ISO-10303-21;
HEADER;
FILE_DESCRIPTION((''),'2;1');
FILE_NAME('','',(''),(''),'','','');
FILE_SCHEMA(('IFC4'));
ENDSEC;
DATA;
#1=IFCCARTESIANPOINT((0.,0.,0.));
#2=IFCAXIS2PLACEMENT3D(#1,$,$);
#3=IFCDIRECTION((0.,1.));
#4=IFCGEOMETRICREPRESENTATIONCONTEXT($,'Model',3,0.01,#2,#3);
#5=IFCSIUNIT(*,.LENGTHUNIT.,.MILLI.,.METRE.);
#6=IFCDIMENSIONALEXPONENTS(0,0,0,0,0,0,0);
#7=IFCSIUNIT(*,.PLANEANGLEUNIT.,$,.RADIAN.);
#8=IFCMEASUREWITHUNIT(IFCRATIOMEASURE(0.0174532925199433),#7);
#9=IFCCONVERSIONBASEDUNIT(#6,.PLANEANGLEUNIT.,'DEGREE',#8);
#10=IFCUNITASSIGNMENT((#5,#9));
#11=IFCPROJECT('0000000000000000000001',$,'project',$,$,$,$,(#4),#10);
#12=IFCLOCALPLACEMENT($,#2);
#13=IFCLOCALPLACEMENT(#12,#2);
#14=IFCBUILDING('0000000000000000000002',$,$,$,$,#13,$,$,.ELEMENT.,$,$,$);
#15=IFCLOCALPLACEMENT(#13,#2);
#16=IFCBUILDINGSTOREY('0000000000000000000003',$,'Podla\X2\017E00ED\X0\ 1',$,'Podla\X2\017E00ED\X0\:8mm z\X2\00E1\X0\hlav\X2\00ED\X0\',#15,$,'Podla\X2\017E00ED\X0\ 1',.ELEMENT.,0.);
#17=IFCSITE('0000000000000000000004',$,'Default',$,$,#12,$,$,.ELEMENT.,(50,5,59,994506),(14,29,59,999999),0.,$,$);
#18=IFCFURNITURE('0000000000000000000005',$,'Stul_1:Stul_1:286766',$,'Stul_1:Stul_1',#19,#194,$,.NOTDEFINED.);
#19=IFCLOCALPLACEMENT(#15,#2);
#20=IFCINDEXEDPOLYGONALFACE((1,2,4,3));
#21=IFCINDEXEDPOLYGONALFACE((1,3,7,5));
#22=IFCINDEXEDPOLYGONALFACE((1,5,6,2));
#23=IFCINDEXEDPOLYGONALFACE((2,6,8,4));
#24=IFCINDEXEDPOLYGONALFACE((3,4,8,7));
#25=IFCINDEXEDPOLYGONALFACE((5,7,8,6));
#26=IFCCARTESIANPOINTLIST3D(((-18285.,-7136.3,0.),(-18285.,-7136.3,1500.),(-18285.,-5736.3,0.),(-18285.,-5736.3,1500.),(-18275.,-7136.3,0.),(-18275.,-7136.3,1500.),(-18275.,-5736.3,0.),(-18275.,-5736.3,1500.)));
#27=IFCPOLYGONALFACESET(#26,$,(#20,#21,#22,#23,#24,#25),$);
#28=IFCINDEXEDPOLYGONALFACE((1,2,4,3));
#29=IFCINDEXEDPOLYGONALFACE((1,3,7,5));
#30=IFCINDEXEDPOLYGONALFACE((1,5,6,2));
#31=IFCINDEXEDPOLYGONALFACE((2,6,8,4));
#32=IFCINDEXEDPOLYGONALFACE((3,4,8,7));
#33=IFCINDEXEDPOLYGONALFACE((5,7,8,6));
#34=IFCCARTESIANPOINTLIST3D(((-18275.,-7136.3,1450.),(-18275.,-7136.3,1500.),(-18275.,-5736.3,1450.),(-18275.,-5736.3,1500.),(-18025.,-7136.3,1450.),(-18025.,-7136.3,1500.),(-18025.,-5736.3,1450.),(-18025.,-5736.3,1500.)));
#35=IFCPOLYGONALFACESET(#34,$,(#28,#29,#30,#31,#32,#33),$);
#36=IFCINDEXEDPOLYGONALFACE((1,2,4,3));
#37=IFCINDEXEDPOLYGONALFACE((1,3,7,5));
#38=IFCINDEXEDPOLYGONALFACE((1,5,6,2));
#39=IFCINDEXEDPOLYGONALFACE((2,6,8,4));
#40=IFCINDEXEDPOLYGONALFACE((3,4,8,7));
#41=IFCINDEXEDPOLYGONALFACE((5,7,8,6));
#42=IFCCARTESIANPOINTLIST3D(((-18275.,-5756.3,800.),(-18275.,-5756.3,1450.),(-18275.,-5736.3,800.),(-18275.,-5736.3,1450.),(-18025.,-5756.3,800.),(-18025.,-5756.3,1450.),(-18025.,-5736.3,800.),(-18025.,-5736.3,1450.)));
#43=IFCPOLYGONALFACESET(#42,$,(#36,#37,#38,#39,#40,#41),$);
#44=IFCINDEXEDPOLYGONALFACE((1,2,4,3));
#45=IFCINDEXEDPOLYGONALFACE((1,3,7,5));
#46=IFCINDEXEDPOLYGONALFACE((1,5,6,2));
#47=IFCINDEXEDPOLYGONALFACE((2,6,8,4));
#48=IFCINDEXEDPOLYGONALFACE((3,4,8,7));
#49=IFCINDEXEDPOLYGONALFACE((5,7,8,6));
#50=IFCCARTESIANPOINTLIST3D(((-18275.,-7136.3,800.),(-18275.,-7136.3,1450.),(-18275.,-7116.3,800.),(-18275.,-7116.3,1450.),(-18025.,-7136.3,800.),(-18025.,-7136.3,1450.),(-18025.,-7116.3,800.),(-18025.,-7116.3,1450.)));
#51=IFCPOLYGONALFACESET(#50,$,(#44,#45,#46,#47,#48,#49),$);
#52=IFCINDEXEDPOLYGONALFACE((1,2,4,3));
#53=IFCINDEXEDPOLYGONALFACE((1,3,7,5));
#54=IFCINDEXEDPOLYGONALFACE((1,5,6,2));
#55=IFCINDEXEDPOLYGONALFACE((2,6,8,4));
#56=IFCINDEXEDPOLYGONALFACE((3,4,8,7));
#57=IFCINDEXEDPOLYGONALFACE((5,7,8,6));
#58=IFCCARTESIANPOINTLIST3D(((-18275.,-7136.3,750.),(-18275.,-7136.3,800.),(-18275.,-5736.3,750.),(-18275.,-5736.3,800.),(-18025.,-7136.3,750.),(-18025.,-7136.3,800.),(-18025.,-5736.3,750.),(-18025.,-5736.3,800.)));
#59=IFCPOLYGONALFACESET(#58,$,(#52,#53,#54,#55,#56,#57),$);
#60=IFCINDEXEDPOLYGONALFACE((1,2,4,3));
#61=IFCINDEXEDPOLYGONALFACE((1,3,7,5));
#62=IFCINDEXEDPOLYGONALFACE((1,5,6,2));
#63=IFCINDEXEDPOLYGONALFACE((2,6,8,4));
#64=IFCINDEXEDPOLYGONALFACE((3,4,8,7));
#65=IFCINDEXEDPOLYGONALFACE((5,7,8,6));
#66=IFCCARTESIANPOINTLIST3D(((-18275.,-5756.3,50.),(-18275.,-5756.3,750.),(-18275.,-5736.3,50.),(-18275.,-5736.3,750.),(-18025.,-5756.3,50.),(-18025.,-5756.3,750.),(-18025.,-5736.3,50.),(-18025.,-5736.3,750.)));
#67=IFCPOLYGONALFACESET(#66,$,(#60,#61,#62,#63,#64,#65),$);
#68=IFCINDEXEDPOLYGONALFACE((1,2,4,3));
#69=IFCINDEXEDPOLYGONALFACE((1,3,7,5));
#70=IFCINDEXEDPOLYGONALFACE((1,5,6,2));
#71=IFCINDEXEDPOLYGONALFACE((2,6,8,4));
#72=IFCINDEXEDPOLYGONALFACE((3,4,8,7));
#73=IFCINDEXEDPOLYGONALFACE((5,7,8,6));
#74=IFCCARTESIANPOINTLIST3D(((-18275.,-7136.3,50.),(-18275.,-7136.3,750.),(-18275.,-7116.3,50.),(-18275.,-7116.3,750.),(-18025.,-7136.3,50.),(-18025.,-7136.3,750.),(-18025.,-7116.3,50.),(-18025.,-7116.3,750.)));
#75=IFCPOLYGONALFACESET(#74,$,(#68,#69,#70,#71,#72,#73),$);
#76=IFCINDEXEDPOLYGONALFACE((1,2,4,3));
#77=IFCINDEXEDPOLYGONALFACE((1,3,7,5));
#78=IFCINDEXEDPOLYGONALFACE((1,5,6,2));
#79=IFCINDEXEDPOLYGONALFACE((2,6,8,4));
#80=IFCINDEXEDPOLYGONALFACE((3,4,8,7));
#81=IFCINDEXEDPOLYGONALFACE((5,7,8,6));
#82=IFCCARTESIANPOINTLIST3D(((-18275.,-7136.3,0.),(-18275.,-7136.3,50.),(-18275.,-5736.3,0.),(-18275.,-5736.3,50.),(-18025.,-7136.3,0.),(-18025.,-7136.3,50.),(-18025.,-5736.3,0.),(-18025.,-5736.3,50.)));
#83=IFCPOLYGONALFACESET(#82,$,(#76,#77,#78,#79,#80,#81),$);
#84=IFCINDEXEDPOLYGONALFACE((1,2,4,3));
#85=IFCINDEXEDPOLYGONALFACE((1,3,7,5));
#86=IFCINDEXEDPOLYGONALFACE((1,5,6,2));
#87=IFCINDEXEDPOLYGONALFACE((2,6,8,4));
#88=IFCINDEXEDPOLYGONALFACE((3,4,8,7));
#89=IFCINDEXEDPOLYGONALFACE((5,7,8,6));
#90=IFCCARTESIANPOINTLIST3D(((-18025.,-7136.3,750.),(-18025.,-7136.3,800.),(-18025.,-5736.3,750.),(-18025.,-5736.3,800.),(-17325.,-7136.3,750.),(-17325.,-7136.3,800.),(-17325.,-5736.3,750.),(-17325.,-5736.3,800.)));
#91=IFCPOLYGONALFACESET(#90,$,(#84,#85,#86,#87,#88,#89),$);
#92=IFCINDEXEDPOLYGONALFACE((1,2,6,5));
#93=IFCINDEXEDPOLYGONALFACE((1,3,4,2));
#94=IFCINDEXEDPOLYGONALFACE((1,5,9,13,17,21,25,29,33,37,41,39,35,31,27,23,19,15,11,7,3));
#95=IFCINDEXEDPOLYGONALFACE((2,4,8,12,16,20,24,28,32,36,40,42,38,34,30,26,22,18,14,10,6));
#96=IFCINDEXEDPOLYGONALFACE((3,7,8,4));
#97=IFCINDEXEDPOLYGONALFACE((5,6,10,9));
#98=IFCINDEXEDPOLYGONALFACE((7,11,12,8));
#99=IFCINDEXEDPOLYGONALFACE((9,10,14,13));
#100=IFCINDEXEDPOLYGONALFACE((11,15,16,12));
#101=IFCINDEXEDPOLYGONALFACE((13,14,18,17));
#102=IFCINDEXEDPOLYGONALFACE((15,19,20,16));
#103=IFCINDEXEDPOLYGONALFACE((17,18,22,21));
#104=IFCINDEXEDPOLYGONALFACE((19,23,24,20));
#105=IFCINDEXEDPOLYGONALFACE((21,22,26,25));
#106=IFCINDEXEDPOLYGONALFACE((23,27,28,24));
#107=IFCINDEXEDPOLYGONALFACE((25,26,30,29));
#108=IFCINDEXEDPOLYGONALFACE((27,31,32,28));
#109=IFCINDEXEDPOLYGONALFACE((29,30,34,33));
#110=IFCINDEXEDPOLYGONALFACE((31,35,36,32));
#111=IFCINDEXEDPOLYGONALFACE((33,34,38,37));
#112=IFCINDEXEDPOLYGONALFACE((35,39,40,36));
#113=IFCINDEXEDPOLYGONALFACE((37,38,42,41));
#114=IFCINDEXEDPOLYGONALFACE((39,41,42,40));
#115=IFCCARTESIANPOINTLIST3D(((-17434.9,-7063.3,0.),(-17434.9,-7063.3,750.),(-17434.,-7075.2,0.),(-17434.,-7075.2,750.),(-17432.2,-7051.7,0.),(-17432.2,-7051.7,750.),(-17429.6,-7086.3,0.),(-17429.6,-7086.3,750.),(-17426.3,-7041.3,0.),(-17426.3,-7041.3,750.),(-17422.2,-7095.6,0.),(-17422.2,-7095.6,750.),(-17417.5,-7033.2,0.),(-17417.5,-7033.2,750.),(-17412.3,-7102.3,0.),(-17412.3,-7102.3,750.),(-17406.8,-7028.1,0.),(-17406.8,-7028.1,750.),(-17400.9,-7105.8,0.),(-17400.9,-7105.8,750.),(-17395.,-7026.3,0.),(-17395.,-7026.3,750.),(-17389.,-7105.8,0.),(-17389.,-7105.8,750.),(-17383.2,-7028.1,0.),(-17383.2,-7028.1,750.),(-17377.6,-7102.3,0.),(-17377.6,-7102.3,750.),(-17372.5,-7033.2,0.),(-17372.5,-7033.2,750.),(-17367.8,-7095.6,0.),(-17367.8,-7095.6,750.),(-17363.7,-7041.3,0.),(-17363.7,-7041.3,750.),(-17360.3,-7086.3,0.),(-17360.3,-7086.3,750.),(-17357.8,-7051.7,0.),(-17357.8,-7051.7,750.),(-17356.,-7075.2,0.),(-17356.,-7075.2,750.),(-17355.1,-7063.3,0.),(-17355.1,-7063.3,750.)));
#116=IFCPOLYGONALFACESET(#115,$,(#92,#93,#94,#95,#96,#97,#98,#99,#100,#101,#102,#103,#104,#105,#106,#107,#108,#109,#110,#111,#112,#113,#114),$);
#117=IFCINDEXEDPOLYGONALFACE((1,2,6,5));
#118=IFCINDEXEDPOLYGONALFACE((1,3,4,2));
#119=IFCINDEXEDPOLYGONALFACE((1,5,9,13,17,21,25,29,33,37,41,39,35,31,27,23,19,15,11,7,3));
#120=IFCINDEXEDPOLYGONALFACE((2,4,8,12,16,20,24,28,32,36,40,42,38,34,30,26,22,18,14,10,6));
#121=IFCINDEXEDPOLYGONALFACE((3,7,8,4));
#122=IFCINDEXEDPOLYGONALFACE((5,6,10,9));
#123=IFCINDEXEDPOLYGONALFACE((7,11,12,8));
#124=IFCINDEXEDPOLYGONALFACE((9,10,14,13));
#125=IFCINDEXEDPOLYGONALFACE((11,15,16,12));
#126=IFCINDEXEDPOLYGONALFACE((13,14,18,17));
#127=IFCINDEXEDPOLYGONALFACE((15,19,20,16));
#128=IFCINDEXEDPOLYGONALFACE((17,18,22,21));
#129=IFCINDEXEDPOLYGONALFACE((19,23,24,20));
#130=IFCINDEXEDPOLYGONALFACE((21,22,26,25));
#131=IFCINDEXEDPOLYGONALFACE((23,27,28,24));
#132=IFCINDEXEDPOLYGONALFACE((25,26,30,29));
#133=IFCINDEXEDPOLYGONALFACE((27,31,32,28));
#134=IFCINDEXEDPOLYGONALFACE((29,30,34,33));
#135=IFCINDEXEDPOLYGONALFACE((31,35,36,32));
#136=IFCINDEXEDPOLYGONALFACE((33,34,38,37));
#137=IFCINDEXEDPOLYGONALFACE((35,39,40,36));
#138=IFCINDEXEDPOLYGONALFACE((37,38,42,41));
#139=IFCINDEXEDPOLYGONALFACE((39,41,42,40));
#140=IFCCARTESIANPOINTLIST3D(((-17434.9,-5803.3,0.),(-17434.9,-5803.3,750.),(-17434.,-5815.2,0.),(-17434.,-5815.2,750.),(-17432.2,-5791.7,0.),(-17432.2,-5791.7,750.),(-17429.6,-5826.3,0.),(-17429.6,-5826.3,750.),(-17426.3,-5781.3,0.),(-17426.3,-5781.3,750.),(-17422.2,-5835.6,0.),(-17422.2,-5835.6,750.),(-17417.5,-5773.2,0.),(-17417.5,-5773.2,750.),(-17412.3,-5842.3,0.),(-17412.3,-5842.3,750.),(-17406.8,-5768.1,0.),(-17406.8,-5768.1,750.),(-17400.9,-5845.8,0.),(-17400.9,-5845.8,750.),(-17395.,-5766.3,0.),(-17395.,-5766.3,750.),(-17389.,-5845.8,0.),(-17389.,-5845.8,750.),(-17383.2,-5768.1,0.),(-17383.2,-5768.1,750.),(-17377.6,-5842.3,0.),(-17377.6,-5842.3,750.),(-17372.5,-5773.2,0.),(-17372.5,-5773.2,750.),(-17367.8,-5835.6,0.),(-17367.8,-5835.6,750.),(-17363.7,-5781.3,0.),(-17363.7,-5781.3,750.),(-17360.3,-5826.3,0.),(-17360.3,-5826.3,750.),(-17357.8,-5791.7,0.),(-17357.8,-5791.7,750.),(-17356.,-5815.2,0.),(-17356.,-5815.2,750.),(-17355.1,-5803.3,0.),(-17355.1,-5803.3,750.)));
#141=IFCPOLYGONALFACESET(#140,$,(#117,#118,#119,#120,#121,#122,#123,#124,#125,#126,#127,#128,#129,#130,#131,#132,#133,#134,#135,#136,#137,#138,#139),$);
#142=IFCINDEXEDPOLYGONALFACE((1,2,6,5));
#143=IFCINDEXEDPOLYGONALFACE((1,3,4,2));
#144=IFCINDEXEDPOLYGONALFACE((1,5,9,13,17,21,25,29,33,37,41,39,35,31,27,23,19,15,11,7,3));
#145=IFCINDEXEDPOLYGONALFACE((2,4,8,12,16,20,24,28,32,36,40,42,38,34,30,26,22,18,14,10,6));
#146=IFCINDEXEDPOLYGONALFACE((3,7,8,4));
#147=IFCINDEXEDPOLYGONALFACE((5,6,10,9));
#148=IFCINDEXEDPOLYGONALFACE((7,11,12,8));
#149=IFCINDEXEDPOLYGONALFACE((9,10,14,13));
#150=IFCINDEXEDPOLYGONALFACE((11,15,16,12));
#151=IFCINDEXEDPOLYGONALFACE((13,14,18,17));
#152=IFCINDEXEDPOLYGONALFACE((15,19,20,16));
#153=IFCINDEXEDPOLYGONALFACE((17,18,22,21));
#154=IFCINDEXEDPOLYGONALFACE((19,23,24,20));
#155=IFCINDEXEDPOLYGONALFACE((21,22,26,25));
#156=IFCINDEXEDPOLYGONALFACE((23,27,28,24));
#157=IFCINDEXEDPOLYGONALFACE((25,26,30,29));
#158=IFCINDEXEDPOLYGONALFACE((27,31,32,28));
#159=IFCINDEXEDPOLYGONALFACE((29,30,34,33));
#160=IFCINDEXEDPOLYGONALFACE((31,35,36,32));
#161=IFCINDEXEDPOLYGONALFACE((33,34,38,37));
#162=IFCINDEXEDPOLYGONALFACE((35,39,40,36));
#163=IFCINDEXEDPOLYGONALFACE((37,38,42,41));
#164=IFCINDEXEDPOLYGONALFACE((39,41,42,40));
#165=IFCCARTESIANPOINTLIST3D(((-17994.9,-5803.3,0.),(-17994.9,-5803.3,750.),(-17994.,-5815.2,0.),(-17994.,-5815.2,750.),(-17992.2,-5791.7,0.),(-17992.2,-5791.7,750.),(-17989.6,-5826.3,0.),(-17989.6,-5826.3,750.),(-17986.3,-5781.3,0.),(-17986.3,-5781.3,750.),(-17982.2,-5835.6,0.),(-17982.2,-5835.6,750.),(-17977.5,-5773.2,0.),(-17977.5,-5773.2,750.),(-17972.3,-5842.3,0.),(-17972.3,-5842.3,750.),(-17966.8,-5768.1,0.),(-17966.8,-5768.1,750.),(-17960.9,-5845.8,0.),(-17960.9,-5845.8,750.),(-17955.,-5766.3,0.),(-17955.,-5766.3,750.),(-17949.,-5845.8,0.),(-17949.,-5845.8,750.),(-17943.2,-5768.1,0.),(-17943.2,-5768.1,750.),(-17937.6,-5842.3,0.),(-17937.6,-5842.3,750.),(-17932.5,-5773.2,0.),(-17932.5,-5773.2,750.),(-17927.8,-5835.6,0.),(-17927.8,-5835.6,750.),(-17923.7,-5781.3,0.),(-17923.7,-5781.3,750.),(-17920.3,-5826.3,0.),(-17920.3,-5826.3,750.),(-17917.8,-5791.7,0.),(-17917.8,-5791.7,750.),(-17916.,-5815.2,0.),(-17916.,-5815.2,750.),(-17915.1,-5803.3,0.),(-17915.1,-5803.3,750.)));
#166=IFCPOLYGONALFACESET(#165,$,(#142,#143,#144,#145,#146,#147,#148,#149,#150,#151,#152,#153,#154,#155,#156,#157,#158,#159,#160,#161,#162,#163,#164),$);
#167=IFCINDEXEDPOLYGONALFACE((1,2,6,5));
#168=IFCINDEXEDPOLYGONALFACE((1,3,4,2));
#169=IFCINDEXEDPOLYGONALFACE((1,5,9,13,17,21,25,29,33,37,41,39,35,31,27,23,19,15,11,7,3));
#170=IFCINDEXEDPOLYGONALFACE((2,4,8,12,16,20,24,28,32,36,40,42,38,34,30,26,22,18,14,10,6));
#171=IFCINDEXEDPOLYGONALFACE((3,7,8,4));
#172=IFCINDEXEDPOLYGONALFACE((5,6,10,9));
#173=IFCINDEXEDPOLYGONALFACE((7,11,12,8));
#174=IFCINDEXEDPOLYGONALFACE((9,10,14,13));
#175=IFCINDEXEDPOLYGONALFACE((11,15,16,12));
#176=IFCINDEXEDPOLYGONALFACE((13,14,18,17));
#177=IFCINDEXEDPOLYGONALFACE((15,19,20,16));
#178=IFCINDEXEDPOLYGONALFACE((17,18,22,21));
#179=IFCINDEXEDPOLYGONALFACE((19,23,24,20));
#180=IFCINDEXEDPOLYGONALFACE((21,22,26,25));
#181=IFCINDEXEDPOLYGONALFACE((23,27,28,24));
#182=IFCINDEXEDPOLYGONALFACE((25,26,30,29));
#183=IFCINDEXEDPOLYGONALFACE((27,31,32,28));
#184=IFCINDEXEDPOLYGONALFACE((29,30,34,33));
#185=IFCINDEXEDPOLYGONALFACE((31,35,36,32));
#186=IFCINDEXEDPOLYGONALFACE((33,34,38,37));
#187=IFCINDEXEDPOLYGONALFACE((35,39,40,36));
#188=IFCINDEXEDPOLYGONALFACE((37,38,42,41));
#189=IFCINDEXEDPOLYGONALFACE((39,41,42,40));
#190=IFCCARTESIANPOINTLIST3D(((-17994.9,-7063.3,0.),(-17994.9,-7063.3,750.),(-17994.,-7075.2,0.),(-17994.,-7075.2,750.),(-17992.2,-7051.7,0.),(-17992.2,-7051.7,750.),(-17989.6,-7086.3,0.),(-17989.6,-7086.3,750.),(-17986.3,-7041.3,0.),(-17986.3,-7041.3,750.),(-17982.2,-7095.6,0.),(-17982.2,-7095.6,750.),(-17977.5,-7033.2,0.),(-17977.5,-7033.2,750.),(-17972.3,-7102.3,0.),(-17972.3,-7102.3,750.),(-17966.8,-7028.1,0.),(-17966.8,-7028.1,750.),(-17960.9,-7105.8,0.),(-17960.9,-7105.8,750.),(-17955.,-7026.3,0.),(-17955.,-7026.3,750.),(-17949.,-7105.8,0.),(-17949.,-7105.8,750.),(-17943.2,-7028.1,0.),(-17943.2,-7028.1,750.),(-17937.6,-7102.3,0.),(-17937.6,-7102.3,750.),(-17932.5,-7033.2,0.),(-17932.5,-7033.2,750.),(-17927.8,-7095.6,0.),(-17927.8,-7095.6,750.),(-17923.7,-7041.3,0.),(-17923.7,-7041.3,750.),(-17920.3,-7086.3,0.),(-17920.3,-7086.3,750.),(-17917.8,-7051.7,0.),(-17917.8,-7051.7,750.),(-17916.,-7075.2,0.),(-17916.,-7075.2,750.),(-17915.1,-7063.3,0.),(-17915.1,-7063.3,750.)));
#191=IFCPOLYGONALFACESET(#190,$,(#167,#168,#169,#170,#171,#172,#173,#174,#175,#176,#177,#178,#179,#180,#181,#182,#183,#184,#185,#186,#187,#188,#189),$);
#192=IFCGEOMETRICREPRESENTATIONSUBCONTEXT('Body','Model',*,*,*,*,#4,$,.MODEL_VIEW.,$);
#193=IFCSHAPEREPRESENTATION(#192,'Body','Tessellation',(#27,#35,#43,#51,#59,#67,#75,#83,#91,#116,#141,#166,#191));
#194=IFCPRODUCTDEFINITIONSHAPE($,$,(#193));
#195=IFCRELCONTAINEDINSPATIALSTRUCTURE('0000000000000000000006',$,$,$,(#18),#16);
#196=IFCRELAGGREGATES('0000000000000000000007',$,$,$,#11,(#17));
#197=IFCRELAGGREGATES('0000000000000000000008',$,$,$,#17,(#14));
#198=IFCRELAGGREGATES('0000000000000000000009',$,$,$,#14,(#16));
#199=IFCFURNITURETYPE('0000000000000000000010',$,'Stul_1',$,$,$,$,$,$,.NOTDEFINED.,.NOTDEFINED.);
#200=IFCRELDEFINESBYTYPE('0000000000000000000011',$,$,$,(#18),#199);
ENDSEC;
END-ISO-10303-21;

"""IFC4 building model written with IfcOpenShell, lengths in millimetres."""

from ifc_helpers import new_model, entity, si_unit, converted_unit, direction, frame, frame_2d, origin, origin_2d_with_axis, place, context, subcontext, project, spatial, rectangle, circle, extrude, source, transform, mapped, type_object, type_shapes, element, save


model = new_model("IFC4")

# Units and contexts
model_context = context("Model", 3, precision=0.01, world=origin(), true_north=direction((0.0, 1.0)))
body_context = subcontext(model_context, "Body", "Model", "MODEL_VIEW")
ifc_project = project(units=[si_unit("LENGTHUNIT", "METRE", prefix="MILLI"), converted_unit("PLANEANGLEUNIT", "DEGREE", entity("IfcRatioMeasure", 0.0174532925199433), si_unit("PLANEANGLEUNIT", "RADIAN"), dimensions=[0, 0, 0, 0, 0, 0, 0])], contexts=[model_context])

# Site, building, storey
site_placement = place(None, origin())
site = spatial("IfcSite", under=ifc_project, at=site_placement, Name="Default", CompositionType="ELEMENT", RefLatitude=(50, 5, 59, 994506), RefLongitude=(14, 29, 59, 999999), RefElevation=0.0)
building_placement = place(site_placement, origin())
building = spatial("IfcBuilding", under=site, at=building_placement, CompositionType="ELEMENT")
storey_placement = place(building_placement, origin())
storey = spatial("IfcBuildingStorey", under=building, at=storey_placement, Name="Podlaží 1", ObjectType="Podlaží:8mm záhlaví", LongName="Podlaží 1", CompositionType="ELEMENT", Elevation=0.0)

# Furniture
furniture_type = type_object("IfcFurnitureType", Name="Stul_1", AssemblyPlace="NOTDEFINED", PredefinedType="NOTDEFINED")
shared_shape_1 = source(origin(), body_context, "Body", "SweptSolid", [
    extrude(rectangle(XDim=1400.0, YDim=10.0, at=origin_2d_with_axis()), frame((0.0, 605.0, 0.0), z_axis=(0.0, 0.0, 1.0), x_axis=(-1.0, 0.0, 0.0)), (0.0, 0.0, 1.0), 1500.0),
    extrude(rectangle(XDim=1400.0, YDim=250.0, at=frame_2d((0.0, 0.0), x_axis=(1.0, 0.0))), frame((0.0, 475.0, 1450.0), z_axis=(0.0, 0.0, 1.0), x_axis=(-1.0, 0.0, 0.0)), (0.0, 0.0, 1.0), 50.0),
    extrude(rectangle(XDim=20.0, YDim=250.0, at=origin_2d_with_axis()), frame((690.0, 475.0, 800.0), z_axis=(0.0, 0.0, 1.0), x_axis=(-1.0, 0.0, 0.0)), (0.0, 0.0, 1.0), 650.0),
    extrude(rectangle(XDim=20.0, YDim=250.0, at=frame_2d((0.0, 0.0), x_axis=(1.0, 0.0))), frame((-690.0, 475.0, 800.0), z_axis=(0.0, 0.0, 1.0), x_axis=(-1.0, 0.0, 0.0)), (0.0, 0.0, 1.0), 650.0),
    extrude(rectangle(XDim=1400.0, YDim=250.0, at=origin_2d_with_axis()), frame((0.0, 475.0, 750.0), z_axis=(0.0, 0.0, 1.0), x_axis=(-1.0, 0.0, 0.0)), (0.0, 0.0, 1.0), 50.0),
    extrude(rectangle(XDim=20.0, YDim=250.0, at=origin_2d_with_axis()), frame((690.0, 475.0, 50.0), z_axis=(0.0, 0.0, 1.0), x_axis=(-1.0, 0.0, 0.0)), (0.0, 0.0, 1.0), 700.0),
    extrude(rectangle(XDim=20.0, YDim=250.0, at=frame_2d((0.0, 0.0), x_axis=(1.0, 0.0))), frame((-690.0, 475.0, 50.0), z_axis=(0.0, 0.0, 1.0), x_axis=(-1.0, 0.0, 0.0)), (0.0, 0.0, 1.0), 700.0),
    extrude(rectangle(XDim=1400.0, YDim=250.0, at=origin_2d_with_axis()), frame((0.0, 475.0, 0.0), z_axis=(0.0, 0.0, 1.0), x_axis=(-1.0, 0.0, 0.0)), (0.0, 0.0, 1.0), 50.0),
    extrude(rectangle(XDim=1400.0, YDim=700.0, at=origin_2d_with_axis()), frame((0.0, 0.0, 750.0), z_axis=(0.0, 0.0, 1.0), x_axis=(-1.0, 0.0, 0.0)), (0.0, 0.0, 1.0), 50.0),
    extrude(circle(Radius=40.0, at=frame_2d((0.0, 0.0), x_axis=(1.0, 0.0))), frame((-630.0, -280.0, 0.0)), (0.0, 0.0, 1.0), 750.0),
    extrude(circle(Radius=40.0, at=frame_2d((0.0, 0.0), x_axis=(1.0, 0.0))), frame((630.0, -280.0, 0.0)), (0.0, 0.0, 1.0), 750.0),
    extrude(circle(Radius=40.0, at=frame_2d((0.0, 0.0), x_axis=(1.0, 0.0))), frame((630.0, 280.0, 0.0)), (0.0, 0.0, 1.0), 750.0),
    extrude(circle(Radius=40.0, at=frame_2d((0.0, 0.0), x_axis=(1.0, 0.0))), frame((-630.0, 280.0, 0.0)), (0.0, 0.0, 1.0), 750.0),
])
type_shapes(furniture_type, [shared_shape_1])
for number, where, z_axis, x_axis, name in (
    (1, (-17675.0, -6436.3, 0.0), (0.0, 0.0, 1.0), (0.0, 1.0, 0.0), "Stul_1:Stul_1:286766"),
):
    element("IfcFurniture", number, at=place(storey_placement, frame(where, z_axis=z_axis, x_axis=x_axis)), inside=storey, type_object=furniture_type, Name=name, ObjectType="Stul_1:Stul_1", PredefinedType="NOTDEFINED", context=body_context, shape_type="MappedRepresentation", body=[
        mapped(shared_shape_1, transform((0.0, 0.0, 0.0), scale=1.0)),
    ])

save(model, "model.ifc")
